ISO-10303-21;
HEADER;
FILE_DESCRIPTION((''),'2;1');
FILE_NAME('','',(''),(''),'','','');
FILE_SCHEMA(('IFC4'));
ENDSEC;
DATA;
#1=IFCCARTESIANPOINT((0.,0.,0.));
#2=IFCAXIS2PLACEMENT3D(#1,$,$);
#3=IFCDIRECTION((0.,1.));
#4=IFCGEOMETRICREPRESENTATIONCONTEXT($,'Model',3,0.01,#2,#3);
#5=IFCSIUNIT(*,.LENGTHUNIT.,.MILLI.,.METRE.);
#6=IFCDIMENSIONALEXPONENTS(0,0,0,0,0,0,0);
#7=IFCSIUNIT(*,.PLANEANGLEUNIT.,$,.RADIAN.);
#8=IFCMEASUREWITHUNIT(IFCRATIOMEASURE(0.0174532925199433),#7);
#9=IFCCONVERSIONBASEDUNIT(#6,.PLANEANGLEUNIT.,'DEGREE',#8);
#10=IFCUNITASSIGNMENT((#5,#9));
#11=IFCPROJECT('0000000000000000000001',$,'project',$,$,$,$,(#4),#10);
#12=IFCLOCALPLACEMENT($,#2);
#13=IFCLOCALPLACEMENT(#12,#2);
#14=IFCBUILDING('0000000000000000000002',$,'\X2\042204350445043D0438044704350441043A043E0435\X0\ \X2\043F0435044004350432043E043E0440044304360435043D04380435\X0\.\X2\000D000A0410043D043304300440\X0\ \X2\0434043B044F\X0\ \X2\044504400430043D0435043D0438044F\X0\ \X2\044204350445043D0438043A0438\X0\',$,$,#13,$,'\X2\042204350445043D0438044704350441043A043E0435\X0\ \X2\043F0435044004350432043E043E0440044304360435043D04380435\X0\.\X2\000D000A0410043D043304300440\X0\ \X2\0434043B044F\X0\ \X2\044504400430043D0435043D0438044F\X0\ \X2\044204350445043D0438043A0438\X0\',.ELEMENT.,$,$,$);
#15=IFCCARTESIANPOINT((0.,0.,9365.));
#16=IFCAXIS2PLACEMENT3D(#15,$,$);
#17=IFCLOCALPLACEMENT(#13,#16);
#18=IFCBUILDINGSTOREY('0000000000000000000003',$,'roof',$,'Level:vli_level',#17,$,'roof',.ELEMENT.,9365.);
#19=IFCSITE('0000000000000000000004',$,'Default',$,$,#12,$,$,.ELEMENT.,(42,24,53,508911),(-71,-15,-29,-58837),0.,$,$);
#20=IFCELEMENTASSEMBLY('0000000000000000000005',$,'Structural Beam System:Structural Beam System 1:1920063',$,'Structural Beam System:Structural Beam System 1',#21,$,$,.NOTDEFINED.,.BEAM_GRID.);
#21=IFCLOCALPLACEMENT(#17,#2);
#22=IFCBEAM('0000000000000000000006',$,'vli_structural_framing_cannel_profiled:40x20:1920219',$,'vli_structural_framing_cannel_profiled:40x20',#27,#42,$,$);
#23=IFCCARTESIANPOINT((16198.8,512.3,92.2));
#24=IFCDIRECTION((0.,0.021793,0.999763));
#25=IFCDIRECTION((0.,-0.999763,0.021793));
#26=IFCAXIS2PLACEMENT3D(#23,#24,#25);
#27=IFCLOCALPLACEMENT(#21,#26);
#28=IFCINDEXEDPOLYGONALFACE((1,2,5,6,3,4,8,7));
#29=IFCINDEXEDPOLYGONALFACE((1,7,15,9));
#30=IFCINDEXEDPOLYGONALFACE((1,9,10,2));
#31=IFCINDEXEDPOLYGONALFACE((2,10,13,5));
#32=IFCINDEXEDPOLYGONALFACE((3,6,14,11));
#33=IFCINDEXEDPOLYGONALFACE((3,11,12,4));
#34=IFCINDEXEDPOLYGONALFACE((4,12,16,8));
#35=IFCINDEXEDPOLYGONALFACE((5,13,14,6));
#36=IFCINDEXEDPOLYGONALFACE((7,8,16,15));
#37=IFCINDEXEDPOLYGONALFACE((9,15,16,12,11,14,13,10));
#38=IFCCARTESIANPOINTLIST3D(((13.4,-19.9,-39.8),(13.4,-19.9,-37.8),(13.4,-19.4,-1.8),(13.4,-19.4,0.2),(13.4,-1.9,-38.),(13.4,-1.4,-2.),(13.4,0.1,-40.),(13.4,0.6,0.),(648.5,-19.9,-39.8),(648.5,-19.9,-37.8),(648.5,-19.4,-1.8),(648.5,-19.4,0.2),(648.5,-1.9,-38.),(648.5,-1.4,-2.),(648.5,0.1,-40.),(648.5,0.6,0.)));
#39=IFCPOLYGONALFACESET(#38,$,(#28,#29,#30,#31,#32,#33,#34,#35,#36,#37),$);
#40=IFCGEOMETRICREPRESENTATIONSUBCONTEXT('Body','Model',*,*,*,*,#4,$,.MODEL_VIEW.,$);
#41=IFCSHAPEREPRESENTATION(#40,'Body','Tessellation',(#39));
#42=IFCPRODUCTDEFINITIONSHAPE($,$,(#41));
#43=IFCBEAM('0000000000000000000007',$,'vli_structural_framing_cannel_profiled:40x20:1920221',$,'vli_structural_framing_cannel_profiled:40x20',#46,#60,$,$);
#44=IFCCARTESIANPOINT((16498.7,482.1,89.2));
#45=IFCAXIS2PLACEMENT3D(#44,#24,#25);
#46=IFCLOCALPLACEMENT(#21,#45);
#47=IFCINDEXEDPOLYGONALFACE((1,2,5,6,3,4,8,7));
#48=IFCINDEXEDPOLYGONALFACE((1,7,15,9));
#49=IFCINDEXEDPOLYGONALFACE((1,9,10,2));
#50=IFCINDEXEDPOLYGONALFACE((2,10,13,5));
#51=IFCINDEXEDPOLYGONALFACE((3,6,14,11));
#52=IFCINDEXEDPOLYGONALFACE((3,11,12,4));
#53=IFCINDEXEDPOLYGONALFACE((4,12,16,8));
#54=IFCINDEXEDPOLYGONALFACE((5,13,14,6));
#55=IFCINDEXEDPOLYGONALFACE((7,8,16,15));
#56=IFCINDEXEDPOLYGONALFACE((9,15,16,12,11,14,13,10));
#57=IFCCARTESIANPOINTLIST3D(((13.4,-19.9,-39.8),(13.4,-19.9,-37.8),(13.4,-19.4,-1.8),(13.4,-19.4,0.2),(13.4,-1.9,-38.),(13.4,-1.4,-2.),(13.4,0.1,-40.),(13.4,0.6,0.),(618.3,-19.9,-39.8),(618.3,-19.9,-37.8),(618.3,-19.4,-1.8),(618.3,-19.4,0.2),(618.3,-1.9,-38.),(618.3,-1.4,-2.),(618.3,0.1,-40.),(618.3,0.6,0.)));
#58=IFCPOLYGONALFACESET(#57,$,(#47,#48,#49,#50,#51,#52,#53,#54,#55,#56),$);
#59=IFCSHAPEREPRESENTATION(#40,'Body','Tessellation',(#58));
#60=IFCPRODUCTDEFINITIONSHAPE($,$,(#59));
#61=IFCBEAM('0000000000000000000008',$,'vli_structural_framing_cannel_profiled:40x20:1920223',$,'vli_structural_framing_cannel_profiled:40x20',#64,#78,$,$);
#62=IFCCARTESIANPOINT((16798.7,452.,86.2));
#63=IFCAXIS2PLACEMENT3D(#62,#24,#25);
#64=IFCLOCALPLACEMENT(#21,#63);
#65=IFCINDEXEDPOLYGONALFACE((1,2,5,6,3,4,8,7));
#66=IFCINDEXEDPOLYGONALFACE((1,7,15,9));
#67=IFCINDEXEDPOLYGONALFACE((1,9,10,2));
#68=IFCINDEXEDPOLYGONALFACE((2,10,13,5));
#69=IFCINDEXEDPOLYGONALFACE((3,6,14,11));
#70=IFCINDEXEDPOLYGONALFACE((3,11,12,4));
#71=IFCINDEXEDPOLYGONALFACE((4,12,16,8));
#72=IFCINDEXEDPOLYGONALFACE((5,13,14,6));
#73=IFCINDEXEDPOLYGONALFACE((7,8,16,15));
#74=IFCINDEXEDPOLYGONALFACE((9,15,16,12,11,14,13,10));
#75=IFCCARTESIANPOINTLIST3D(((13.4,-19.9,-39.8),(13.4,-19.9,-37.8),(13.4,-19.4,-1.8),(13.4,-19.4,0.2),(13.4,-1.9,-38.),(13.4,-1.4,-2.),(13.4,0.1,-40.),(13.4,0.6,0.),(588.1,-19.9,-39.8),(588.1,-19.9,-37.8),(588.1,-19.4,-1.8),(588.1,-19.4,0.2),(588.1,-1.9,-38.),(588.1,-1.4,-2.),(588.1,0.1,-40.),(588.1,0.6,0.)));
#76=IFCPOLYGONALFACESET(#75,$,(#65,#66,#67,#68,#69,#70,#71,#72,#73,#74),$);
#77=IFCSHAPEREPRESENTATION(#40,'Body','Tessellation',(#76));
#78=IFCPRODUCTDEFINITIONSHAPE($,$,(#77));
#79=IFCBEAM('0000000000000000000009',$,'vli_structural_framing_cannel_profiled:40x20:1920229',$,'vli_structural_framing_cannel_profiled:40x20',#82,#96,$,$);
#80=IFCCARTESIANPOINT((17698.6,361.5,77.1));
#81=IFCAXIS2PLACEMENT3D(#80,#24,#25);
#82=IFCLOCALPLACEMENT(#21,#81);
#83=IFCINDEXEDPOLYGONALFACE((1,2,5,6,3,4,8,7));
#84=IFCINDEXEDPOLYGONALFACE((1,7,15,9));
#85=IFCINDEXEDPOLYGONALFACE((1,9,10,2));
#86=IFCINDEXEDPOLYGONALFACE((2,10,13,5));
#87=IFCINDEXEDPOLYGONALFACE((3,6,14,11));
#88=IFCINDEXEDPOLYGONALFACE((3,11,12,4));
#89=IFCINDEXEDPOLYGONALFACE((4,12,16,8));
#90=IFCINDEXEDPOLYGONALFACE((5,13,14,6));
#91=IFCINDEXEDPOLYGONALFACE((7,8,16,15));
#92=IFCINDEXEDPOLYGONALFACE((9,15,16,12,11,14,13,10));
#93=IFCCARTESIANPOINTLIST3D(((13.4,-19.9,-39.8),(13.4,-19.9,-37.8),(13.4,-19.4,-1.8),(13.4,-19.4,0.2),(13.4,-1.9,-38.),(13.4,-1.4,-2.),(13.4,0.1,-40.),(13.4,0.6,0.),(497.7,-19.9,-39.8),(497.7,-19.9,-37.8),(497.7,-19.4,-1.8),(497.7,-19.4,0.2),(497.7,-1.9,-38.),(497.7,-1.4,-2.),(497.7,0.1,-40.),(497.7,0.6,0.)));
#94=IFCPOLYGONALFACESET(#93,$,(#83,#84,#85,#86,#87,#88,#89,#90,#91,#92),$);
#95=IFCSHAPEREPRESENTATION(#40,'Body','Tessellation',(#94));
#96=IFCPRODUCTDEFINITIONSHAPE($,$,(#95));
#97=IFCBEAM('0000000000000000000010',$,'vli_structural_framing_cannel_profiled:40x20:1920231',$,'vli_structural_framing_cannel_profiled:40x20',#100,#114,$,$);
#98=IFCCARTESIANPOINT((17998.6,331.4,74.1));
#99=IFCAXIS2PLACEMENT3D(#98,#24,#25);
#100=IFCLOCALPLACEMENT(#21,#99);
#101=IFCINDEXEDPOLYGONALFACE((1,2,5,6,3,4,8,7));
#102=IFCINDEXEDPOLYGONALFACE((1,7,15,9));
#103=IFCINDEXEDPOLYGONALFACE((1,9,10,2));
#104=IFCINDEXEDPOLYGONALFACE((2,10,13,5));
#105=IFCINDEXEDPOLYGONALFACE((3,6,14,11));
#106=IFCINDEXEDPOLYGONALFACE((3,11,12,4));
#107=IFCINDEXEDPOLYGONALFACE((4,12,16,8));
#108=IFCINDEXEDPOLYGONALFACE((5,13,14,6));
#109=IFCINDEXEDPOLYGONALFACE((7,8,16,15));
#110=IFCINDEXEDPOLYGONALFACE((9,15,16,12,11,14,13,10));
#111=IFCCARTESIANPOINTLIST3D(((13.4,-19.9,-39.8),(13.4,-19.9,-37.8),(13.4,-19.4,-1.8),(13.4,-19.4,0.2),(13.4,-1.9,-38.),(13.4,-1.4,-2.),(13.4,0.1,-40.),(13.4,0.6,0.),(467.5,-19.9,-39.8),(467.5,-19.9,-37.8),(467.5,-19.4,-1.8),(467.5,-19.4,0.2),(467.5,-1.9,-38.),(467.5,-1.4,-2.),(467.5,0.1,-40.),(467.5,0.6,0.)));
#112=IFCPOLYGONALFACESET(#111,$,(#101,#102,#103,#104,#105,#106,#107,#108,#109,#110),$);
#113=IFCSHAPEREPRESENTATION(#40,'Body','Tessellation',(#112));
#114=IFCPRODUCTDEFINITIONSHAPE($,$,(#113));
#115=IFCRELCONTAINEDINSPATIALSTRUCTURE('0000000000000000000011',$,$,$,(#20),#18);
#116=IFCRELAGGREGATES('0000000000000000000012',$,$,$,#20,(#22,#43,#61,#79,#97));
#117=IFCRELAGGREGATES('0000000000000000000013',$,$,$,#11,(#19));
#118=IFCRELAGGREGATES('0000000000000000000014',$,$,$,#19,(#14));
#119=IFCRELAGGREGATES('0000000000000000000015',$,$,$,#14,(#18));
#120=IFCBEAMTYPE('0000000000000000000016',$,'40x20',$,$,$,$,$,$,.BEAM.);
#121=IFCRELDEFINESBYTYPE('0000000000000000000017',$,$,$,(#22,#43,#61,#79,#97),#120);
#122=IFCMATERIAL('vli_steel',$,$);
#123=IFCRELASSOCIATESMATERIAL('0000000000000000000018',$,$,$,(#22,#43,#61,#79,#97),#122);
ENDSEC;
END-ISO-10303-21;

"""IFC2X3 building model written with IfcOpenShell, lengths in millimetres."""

from ifc_helpers import new_model, entity, si_unit, converted_unit, direction, frame, origin, place, context, subcontext, project, spatial, polyline, outline, extrude, material, type_object, element, aggregate, save


model = new_model("IFC2X3")

# Units and contexts
model_context = context("Model", 3, precision=0.01, world=origin(), true_north=direction((0.0, 1.0)))
body_context = subcontext(model_context, "Body", "Model", "MODEL_VIEW")
ifc_project = project(units=[si_unit("LENGTHUNIT", "METRE", prefix="MILLI"), converted_unit("PLANEANGLEUNIT", "DEGREE", entity("IfcRatioMeasure", 0.0174532925199433), si_unit("PLANEANGLEUNIT", "RADIAN"), dimensions=[0, 0, 0, 0, 0, 0, 0])], contexts=[model_context])

# Site, building, storey
site_placement = place(None, origin())
site = spatial("IfcSite", under=ifc_project, at=site_placement, Name="Default", CompositionType="ELEMENT", RefLatitude=(42, 24, 53, 508911), RefLongitude=(-71, -15, -29, -58837), RefElevation=0.0)
building_placement = place(site_placement, origin())
building = spatial("IfcBuilding", under=site, at=building_placement, Name="Техническое перевооружение.\r\nАнгар для хранения техники", LongName="Техническое перевооружение.\r\nАнгар для хранения техники", CompositionType="ELEMENT")
storey_placement = place(building_placement, frame((0.0, 0.0, 9365.0)))
storey = spatial("IfcBuildingStorey", under=building, at=storey_placement, Name="roof", ObjectType="Level:vli_level", LongName="roof", CompositionType="ELEMENT", Elevation=9365.0)

# Element assembly, beams
ifc_material = material(Name="vli_steel")
beam_type = type_object("IfcBeamType", Name="40x20", PredefinedType="BEAM")
assembly_1_placement = place(storey_placement, origin())
assembly_1 = element("IfcElementAssembly", 1, at=assembly_1_placement, inside=storey, Name="Structural Beam System:Structural Beam System 1:1920063", ObjectType="Structural Beam System:Structural Beam System 1", AssemblyPlace="NOTDEFINED", PredefinedType="BEAM_GRID")
beam_1_placement = place(assembly_1_placement, frame((16198.8, 512.3, 92.2), z_axis=(0.0, 0.021793, 0.999763), x_axis=(0.0, -0.999763, 0.021793)))
beam_1 = element("IfcBeam", 2, at=beam_1_placement, type_object=beam_type, material=ifc_material, Name="vli_structural_framing_cannel_profiled:40x20:1920219", ObjectType="vli_structural_framing_cannel_profiled:40x20", context=body_context, shape_type="SweptSolid", body=[
    extrude(outline(polyline([(-10.5, -20.0), (9.5, -20.0), (9.5, -18.0), (-8.5, -18.0), (-8.5, 18.0), (9.5, 18.0), (9.5, 20.0), (-10.5, 20.0), (-10.5, -20.0)])), frame((13.4, -10.1, -19.9), z_axis=(1.0, 0.0, 0.0), x_axis=(0.0, -0.999925, 0.012237)), (0.0, 0.0, 1.0), 635.1),
])
beam_2_placement = place(assembly_1_placement, frame((16498.7, 482.1, 89.2), z_axis=(0.0, 0.021793, 0.999763), x_axis=(0.0, -0.999763, 0.021793)))
beam_2 = element("IfcBeam", 3, at=beam_2_placement, type_object=beam_type, material=ifc_material, Name="vli_structural_framing_cannel_profiled:40x20:1920221", ObjectType="vli_structural_framing_cannel_profiled:40x20", context=body_context, shape_type="SweptSolid", body=[
    extrude(outline(polyline([(-10.5, -20.0), (9.5, -20.0), (9.5, -18.0), (-8.5, -18.0), (-8.5, 18.0), (9.5, 18.0), (9.5, 20.0), (-10.5, 20.0), (-10.5, -20.0)])), frame((13.4, -10.1, -19.9), z_axis=(1.0, 0.0, 0.0), x_axis=(0.0, -0.999925, 0.012237)), (0.0, 0.0, 1.0), 604.9),
])
beam_3_placement = place(assembly_1_placement, frame((16798.7, 452.0, 86.2), z_axis=(0.0, 0.021793, 0.999763), x_axis=(0.0, -0.999763, 0.021793)))
beam_3 = element("IfcBeam", 4, at=beam_3_placement, type_object=beam_type, material=ifc_material, Name="vli_structural_framing_cannel_profiled:40x20:1920223", ObjectType="vli_structural_framing_cannel_profiled:40x20", context=body_context, shape_type="SweptSolid", body=[
    extrude(outline(polyline([(-10.5, -20.0), (9.5, -20.0), (9.5, -18.0), (-8.5, -18.0), (-8.5, 18.0), (9.5, 18.0), (9.5, 20.0), (-10.5, 20.0), (-10.5, -20.0)])), frame((13.4, -10.1, -19.9), z_axis=(1.0, 0.0, 0.0), x_axis=(0.0, -0.999925, 0.012237)), (0.0, 0.0, 1.0), 574.8),
])
beam_4_placement = place(assembly_1_placement, frame((17698.6, 361.5, 77.1), z_axis=(0.0, 0.021793, 0.999763), x_axis=(0.0, -0.999763, 0.021793)))
beam_4 = element("IfcBeam", 5, at=beam_4_placement, type_object=beam_type, material=ifc_material, Name="vli_structural_framing_cannel_profiled:40x20:1920229", ObjectType="vli_structural_framing_cannel_profiled:40x20", context=body_context, shape_type="SweptSolid", body=[
    extrude(outline(polyline([(-10.5, -20.0), (9.5, -20.0), (9.5, -18.0), (-8.5, -18.0), (-8.5, 18.0), (9.5, 18.0), (9.5, 20.0), (-10.5, 20.0), (-10.5, -20.0)])), frame((13.4, -10.1, -19.9), z_axis=(1.0, 0.0, 0.0), x_axis=(0.0, -0.999925, 0.012237)), (0.0, 0.0, 1.0), 484.3),
])
beam_5_placement = place(assembly_1_placement, frame((17998.6, 331.4, 74.1), z_axis=(0.0, 0.021793, 0.999763), x_axis=(0.0, -0.999763, 0.021793)))
beam_5 = element("IfcBeam", 6, at=beam_5_placement, type_object=beam_type, material=ifc_material, Name="vli_structural_framing_cannel_profiled:40x20:1920231", ObjectType="vli_structural_framing_cannel_profiled:40x20", context=body_context, shape_type="SweptSolid", body=[
    extrude(outline(polyline([(-10.5, -20.0), (9.5, -20.0), (9.5, -18.0), (-8.5, -18.0), (-8.5, 18.0), (9.5, 18.0), (9.5, 20.0), (-10.5, 20.0), (-10.5, -20.0)])), frame((13.4, -10.1, -19.9), z_axis=(1.0, 0.0, 0.0), x_axis=(0.0, -0.999925, 0.012237)), (0.0, 0.0, 1.0), 454.2),
])
aggregate(assembly_1, [beam_1, beam_2, beam_3, beam_4, beam_5])

save(model, "model.ifc")
